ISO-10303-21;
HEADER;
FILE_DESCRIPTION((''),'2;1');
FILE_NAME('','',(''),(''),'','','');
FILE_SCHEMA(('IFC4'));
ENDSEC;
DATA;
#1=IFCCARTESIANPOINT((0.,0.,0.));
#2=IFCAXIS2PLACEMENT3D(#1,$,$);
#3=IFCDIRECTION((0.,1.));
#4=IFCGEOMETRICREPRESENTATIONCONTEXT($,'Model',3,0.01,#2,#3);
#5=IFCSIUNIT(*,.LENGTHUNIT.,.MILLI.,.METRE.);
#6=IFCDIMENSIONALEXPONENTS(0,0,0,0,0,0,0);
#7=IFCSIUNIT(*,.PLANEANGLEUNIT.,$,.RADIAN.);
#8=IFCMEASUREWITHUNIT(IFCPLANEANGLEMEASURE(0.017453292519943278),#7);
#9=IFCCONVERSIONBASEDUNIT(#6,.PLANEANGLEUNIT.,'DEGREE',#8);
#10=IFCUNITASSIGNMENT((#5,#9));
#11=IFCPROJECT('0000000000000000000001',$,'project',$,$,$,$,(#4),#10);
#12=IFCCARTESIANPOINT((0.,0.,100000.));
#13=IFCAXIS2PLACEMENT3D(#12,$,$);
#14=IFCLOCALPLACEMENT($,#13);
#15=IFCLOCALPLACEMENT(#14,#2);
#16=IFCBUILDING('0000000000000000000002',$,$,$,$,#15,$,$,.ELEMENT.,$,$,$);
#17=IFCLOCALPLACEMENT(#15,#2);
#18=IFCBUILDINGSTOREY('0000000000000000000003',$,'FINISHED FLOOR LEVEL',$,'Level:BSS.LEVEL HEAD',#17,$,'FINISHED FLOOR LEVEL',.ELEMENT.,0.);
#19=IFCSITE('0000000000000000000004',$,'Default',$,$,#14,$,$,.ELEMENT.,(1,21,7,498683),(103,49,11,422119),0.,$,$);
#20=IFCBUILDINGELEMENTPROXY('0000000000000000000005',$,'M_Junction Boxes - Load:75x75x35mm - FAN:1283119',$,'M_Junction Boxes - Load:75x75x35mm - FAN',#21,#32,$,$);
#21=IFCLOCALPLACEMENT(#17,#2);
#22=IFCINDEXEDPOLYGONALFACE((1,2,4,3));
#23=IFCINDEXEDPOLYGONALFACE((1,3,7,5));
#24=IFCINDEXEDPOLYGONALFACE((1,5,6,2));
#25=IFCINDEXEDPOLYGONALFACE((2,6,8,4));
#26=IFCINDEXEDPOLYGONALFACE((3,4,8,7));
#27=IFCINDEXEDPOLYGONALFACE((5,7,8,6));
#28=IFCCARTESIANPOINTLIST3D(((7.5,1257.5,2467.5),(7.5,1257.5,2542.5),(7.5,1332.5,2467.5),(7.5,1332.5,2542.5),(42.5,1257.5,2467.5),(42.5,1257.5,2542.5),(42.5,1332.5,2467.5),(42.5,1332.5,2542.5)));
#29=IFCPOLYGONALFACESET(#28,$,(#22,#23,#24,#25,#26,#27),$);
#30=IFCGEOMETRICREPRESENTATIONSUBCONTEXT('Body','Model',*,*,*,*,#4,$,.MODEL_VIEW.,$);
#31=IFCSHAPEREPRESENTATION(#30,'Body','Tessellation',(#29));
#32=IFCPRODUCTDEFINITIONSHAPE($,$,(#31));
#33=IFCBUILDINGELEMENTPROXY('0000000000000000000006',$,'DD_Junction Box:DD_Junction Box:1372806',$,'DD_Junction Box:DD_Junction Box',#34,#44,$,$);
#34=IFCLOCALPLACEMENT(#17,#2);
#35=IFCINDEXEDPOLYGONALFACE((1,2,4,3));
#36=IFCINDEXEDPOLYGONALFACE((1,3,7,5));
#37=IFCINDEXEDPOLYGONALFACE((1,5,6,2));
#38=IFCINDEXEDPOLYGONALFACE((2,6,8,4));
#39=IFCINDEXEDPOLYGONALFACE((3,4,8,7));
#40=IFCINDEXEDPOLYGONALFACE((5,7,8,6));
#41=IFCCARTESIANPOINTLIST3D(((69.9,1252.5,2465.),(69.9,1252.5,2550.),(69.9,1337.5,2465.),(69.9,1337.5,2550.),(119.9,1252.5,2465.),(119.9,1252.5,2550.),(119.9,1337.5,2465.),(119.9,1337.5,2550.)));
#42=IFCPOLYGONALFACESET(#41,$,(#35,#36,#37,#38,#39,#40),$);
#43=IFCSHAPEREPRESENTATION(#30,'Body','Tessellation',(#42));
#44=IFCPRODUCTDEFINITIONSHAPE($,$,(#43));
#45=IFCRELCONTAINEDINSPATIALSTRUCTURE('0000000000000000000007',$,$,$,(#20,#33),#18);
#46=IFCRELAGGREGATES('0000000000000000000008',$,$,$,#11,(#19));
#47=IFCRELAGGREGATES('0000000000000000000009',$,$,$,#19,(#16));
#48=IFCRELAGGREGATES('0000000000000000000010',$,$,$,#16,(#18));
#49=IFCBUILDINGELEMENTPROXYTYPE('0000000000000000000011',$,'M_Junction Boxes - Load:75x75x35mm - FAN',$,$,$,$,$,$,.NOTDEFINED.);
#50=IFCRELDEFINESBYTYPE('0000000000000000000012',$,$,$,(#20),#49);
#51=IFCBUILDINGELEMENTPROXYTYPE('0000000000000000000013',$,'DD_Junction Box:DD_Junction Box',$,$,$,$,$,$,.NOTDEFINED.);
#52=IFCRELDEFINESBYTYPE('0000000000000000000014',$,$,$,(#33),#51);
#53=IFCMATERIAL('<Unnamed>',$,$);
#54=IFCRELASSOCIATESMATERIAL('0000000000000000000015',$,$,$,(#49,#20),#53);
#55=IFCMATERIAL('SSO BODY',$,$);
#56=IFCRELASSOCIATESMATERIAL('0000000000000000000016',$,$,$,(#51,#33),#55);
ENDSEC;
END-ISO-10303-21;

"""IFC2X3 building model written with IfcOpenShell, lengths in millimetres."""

from ifc_helpers import new_model, entity, si_unit, converted_unit, direction, frame, frame_2d, origin, origin_2d_with_axis, place, context, subcontext, project, spatial, rectangle, extrude, source, transform, mapped, material, type_object, type_shapes, element, save


model = new_model("IFC2X3")

# Units and contexts
model_context = context("Model", 3, precision=0.01, world=origin(), true_north=direction((0.0, 1.0)))
body_context = subcontext(model_context, "Body", "Model", "MODEL_VIEW")
ifc_project = project(units=[si_unit("LENGTHUNIT", "METRE", prefix="MILLI"), converted_unit("PLANEANGLEUNIT", "DEGREE", entity("IfcPlaneAngleMeasure", 0.017453292519943278), si_unit("PLANEANGLEUNIT", "RADIAN"), dimensions=[0, 0, 0, 0, 0, 0, 0])], contexts=[model_context])

# Site, building, storey
site_placement = place(None, frame((0.0, 0.0, 100000.0)))
site = spatial("IfcSite", under=ifc_project, at=site_placement, Name="Default", CompositionType="ELEMENT", RefLatitude=(1, 21, 7, 498683), RefLongitude=(103, 49, 11, 422119), RefElevation=0.0)
building_placement = place(site_placement, origin())
building = spatial("IfcBuilding", under=site, at=building_placement, CompositionType="ELEMENT")
storey_placement = place(building_placement, origin())
storey = spatial("IfcBuildingStorey", under=building, at=storey_placement, Name="FINISHED FLOOR LEVEL", ObjectType="Level:BSS.LEVEL HEAD", LongName="FINISHED FLOOR LEVEL", CompositionType="ELEMENT", Elevation=0.0)

# Shared definitions
ifc_material_1 = material(Name="<Unnamed>")

# Building element proxies
building_element_proxy_type_1 = type_object("IfcBuildingElementProxyType", Name="M_Junction Boxes - Load:75x75x35mm - FAN", PredefinedType="NOTDEFINED", material=ifc_material_1)
shared_shape_1 = source(origin(), body_context, "Body", "SweptSolid", [
    extrude(rectangle(XDim=35.0, YDim=75.0, at=origin_2d_with_axis()), frame((0.0, 0.0, 0.0), z_axis=(0.0, 0.0, 1.0), x_axis=(0.0, 1.0, 0.0)), (0.0, 0.0, 1.0), 75.0),
])
type_shapes(building_element_proxy_type_1, [shared_shape_1])
proxy_1_placement = place(storey_placement, frame((25.0, 1295.0, 2467.5), z_axis=(0.0, 0.0, 1.0), x_axis=(0.0, 1.0, 0.0)))
element("IfcBuildingElementProxy", 1, at=proxy_1_placement, inside=storey, type_object=building_element_proxy_type_1, material=ifc_material_1, Name="M_Junction Boxes - Load:75x75x35mm - FAN:1283119", ObjectType="M_Junction Boxes - Load:75x75x35mm - FAN", context=body_context, shape_type="MappedRepresentation", body=[
    mapped(shared_shape_1, transform((0.0, 0.0, 0.0), scale=1.0)),
])
ifc_material_2 = material(Name="SSO BODY")
building_element_proxy_type_2 = type_object("IfcBuildingElementProxyType", Name="DD_Junction Box:DD_Junction Box", PredefinedType="NOTDEFINED", material=ifc_material_2)
shared_shape_2 = source(origin(), body_context, "Body", "SweptSolid", [
    extrude(rectangle(XDim=85.0, YDim=50.0, at=frame_2d((0.0, 0.0), x_axis=(1.0, 0.0))), frame((0.0, 20.0, -85.0), z_axis=(0.0, 0.0, 1.0), x_axis=(-1.0, 0.0, 0.0)), (0.0, 0.0, 1.0), 85.0),
])
type_shapes(building_element_proxy_type_2, [shared_shape_2])
proxy_2_placement = place(storey_placement, frame((74.9, 1295.0, 2550.0), z_axis=(0.0, 0.0, 1.0), x_axis=(0.0, -1.0, 0.0)))
element("IfcBuildingElementProxy", 2, at=proxy_2_placement, inside=storey, type_object=building_element_proxy_type_2, material=ifc_material_2, Name="DD_Junction Box:DD_Junction Box:1372806", ObjectType="DD_Junction Box:DD_Junction Box", context=body_context, shape_type="MappedRepresentation", body=[
    mapped(shared_shape_2, transform((0.0, 0.0, 0.0), scale=1.0)),
])

save(model, "model.ifc")
